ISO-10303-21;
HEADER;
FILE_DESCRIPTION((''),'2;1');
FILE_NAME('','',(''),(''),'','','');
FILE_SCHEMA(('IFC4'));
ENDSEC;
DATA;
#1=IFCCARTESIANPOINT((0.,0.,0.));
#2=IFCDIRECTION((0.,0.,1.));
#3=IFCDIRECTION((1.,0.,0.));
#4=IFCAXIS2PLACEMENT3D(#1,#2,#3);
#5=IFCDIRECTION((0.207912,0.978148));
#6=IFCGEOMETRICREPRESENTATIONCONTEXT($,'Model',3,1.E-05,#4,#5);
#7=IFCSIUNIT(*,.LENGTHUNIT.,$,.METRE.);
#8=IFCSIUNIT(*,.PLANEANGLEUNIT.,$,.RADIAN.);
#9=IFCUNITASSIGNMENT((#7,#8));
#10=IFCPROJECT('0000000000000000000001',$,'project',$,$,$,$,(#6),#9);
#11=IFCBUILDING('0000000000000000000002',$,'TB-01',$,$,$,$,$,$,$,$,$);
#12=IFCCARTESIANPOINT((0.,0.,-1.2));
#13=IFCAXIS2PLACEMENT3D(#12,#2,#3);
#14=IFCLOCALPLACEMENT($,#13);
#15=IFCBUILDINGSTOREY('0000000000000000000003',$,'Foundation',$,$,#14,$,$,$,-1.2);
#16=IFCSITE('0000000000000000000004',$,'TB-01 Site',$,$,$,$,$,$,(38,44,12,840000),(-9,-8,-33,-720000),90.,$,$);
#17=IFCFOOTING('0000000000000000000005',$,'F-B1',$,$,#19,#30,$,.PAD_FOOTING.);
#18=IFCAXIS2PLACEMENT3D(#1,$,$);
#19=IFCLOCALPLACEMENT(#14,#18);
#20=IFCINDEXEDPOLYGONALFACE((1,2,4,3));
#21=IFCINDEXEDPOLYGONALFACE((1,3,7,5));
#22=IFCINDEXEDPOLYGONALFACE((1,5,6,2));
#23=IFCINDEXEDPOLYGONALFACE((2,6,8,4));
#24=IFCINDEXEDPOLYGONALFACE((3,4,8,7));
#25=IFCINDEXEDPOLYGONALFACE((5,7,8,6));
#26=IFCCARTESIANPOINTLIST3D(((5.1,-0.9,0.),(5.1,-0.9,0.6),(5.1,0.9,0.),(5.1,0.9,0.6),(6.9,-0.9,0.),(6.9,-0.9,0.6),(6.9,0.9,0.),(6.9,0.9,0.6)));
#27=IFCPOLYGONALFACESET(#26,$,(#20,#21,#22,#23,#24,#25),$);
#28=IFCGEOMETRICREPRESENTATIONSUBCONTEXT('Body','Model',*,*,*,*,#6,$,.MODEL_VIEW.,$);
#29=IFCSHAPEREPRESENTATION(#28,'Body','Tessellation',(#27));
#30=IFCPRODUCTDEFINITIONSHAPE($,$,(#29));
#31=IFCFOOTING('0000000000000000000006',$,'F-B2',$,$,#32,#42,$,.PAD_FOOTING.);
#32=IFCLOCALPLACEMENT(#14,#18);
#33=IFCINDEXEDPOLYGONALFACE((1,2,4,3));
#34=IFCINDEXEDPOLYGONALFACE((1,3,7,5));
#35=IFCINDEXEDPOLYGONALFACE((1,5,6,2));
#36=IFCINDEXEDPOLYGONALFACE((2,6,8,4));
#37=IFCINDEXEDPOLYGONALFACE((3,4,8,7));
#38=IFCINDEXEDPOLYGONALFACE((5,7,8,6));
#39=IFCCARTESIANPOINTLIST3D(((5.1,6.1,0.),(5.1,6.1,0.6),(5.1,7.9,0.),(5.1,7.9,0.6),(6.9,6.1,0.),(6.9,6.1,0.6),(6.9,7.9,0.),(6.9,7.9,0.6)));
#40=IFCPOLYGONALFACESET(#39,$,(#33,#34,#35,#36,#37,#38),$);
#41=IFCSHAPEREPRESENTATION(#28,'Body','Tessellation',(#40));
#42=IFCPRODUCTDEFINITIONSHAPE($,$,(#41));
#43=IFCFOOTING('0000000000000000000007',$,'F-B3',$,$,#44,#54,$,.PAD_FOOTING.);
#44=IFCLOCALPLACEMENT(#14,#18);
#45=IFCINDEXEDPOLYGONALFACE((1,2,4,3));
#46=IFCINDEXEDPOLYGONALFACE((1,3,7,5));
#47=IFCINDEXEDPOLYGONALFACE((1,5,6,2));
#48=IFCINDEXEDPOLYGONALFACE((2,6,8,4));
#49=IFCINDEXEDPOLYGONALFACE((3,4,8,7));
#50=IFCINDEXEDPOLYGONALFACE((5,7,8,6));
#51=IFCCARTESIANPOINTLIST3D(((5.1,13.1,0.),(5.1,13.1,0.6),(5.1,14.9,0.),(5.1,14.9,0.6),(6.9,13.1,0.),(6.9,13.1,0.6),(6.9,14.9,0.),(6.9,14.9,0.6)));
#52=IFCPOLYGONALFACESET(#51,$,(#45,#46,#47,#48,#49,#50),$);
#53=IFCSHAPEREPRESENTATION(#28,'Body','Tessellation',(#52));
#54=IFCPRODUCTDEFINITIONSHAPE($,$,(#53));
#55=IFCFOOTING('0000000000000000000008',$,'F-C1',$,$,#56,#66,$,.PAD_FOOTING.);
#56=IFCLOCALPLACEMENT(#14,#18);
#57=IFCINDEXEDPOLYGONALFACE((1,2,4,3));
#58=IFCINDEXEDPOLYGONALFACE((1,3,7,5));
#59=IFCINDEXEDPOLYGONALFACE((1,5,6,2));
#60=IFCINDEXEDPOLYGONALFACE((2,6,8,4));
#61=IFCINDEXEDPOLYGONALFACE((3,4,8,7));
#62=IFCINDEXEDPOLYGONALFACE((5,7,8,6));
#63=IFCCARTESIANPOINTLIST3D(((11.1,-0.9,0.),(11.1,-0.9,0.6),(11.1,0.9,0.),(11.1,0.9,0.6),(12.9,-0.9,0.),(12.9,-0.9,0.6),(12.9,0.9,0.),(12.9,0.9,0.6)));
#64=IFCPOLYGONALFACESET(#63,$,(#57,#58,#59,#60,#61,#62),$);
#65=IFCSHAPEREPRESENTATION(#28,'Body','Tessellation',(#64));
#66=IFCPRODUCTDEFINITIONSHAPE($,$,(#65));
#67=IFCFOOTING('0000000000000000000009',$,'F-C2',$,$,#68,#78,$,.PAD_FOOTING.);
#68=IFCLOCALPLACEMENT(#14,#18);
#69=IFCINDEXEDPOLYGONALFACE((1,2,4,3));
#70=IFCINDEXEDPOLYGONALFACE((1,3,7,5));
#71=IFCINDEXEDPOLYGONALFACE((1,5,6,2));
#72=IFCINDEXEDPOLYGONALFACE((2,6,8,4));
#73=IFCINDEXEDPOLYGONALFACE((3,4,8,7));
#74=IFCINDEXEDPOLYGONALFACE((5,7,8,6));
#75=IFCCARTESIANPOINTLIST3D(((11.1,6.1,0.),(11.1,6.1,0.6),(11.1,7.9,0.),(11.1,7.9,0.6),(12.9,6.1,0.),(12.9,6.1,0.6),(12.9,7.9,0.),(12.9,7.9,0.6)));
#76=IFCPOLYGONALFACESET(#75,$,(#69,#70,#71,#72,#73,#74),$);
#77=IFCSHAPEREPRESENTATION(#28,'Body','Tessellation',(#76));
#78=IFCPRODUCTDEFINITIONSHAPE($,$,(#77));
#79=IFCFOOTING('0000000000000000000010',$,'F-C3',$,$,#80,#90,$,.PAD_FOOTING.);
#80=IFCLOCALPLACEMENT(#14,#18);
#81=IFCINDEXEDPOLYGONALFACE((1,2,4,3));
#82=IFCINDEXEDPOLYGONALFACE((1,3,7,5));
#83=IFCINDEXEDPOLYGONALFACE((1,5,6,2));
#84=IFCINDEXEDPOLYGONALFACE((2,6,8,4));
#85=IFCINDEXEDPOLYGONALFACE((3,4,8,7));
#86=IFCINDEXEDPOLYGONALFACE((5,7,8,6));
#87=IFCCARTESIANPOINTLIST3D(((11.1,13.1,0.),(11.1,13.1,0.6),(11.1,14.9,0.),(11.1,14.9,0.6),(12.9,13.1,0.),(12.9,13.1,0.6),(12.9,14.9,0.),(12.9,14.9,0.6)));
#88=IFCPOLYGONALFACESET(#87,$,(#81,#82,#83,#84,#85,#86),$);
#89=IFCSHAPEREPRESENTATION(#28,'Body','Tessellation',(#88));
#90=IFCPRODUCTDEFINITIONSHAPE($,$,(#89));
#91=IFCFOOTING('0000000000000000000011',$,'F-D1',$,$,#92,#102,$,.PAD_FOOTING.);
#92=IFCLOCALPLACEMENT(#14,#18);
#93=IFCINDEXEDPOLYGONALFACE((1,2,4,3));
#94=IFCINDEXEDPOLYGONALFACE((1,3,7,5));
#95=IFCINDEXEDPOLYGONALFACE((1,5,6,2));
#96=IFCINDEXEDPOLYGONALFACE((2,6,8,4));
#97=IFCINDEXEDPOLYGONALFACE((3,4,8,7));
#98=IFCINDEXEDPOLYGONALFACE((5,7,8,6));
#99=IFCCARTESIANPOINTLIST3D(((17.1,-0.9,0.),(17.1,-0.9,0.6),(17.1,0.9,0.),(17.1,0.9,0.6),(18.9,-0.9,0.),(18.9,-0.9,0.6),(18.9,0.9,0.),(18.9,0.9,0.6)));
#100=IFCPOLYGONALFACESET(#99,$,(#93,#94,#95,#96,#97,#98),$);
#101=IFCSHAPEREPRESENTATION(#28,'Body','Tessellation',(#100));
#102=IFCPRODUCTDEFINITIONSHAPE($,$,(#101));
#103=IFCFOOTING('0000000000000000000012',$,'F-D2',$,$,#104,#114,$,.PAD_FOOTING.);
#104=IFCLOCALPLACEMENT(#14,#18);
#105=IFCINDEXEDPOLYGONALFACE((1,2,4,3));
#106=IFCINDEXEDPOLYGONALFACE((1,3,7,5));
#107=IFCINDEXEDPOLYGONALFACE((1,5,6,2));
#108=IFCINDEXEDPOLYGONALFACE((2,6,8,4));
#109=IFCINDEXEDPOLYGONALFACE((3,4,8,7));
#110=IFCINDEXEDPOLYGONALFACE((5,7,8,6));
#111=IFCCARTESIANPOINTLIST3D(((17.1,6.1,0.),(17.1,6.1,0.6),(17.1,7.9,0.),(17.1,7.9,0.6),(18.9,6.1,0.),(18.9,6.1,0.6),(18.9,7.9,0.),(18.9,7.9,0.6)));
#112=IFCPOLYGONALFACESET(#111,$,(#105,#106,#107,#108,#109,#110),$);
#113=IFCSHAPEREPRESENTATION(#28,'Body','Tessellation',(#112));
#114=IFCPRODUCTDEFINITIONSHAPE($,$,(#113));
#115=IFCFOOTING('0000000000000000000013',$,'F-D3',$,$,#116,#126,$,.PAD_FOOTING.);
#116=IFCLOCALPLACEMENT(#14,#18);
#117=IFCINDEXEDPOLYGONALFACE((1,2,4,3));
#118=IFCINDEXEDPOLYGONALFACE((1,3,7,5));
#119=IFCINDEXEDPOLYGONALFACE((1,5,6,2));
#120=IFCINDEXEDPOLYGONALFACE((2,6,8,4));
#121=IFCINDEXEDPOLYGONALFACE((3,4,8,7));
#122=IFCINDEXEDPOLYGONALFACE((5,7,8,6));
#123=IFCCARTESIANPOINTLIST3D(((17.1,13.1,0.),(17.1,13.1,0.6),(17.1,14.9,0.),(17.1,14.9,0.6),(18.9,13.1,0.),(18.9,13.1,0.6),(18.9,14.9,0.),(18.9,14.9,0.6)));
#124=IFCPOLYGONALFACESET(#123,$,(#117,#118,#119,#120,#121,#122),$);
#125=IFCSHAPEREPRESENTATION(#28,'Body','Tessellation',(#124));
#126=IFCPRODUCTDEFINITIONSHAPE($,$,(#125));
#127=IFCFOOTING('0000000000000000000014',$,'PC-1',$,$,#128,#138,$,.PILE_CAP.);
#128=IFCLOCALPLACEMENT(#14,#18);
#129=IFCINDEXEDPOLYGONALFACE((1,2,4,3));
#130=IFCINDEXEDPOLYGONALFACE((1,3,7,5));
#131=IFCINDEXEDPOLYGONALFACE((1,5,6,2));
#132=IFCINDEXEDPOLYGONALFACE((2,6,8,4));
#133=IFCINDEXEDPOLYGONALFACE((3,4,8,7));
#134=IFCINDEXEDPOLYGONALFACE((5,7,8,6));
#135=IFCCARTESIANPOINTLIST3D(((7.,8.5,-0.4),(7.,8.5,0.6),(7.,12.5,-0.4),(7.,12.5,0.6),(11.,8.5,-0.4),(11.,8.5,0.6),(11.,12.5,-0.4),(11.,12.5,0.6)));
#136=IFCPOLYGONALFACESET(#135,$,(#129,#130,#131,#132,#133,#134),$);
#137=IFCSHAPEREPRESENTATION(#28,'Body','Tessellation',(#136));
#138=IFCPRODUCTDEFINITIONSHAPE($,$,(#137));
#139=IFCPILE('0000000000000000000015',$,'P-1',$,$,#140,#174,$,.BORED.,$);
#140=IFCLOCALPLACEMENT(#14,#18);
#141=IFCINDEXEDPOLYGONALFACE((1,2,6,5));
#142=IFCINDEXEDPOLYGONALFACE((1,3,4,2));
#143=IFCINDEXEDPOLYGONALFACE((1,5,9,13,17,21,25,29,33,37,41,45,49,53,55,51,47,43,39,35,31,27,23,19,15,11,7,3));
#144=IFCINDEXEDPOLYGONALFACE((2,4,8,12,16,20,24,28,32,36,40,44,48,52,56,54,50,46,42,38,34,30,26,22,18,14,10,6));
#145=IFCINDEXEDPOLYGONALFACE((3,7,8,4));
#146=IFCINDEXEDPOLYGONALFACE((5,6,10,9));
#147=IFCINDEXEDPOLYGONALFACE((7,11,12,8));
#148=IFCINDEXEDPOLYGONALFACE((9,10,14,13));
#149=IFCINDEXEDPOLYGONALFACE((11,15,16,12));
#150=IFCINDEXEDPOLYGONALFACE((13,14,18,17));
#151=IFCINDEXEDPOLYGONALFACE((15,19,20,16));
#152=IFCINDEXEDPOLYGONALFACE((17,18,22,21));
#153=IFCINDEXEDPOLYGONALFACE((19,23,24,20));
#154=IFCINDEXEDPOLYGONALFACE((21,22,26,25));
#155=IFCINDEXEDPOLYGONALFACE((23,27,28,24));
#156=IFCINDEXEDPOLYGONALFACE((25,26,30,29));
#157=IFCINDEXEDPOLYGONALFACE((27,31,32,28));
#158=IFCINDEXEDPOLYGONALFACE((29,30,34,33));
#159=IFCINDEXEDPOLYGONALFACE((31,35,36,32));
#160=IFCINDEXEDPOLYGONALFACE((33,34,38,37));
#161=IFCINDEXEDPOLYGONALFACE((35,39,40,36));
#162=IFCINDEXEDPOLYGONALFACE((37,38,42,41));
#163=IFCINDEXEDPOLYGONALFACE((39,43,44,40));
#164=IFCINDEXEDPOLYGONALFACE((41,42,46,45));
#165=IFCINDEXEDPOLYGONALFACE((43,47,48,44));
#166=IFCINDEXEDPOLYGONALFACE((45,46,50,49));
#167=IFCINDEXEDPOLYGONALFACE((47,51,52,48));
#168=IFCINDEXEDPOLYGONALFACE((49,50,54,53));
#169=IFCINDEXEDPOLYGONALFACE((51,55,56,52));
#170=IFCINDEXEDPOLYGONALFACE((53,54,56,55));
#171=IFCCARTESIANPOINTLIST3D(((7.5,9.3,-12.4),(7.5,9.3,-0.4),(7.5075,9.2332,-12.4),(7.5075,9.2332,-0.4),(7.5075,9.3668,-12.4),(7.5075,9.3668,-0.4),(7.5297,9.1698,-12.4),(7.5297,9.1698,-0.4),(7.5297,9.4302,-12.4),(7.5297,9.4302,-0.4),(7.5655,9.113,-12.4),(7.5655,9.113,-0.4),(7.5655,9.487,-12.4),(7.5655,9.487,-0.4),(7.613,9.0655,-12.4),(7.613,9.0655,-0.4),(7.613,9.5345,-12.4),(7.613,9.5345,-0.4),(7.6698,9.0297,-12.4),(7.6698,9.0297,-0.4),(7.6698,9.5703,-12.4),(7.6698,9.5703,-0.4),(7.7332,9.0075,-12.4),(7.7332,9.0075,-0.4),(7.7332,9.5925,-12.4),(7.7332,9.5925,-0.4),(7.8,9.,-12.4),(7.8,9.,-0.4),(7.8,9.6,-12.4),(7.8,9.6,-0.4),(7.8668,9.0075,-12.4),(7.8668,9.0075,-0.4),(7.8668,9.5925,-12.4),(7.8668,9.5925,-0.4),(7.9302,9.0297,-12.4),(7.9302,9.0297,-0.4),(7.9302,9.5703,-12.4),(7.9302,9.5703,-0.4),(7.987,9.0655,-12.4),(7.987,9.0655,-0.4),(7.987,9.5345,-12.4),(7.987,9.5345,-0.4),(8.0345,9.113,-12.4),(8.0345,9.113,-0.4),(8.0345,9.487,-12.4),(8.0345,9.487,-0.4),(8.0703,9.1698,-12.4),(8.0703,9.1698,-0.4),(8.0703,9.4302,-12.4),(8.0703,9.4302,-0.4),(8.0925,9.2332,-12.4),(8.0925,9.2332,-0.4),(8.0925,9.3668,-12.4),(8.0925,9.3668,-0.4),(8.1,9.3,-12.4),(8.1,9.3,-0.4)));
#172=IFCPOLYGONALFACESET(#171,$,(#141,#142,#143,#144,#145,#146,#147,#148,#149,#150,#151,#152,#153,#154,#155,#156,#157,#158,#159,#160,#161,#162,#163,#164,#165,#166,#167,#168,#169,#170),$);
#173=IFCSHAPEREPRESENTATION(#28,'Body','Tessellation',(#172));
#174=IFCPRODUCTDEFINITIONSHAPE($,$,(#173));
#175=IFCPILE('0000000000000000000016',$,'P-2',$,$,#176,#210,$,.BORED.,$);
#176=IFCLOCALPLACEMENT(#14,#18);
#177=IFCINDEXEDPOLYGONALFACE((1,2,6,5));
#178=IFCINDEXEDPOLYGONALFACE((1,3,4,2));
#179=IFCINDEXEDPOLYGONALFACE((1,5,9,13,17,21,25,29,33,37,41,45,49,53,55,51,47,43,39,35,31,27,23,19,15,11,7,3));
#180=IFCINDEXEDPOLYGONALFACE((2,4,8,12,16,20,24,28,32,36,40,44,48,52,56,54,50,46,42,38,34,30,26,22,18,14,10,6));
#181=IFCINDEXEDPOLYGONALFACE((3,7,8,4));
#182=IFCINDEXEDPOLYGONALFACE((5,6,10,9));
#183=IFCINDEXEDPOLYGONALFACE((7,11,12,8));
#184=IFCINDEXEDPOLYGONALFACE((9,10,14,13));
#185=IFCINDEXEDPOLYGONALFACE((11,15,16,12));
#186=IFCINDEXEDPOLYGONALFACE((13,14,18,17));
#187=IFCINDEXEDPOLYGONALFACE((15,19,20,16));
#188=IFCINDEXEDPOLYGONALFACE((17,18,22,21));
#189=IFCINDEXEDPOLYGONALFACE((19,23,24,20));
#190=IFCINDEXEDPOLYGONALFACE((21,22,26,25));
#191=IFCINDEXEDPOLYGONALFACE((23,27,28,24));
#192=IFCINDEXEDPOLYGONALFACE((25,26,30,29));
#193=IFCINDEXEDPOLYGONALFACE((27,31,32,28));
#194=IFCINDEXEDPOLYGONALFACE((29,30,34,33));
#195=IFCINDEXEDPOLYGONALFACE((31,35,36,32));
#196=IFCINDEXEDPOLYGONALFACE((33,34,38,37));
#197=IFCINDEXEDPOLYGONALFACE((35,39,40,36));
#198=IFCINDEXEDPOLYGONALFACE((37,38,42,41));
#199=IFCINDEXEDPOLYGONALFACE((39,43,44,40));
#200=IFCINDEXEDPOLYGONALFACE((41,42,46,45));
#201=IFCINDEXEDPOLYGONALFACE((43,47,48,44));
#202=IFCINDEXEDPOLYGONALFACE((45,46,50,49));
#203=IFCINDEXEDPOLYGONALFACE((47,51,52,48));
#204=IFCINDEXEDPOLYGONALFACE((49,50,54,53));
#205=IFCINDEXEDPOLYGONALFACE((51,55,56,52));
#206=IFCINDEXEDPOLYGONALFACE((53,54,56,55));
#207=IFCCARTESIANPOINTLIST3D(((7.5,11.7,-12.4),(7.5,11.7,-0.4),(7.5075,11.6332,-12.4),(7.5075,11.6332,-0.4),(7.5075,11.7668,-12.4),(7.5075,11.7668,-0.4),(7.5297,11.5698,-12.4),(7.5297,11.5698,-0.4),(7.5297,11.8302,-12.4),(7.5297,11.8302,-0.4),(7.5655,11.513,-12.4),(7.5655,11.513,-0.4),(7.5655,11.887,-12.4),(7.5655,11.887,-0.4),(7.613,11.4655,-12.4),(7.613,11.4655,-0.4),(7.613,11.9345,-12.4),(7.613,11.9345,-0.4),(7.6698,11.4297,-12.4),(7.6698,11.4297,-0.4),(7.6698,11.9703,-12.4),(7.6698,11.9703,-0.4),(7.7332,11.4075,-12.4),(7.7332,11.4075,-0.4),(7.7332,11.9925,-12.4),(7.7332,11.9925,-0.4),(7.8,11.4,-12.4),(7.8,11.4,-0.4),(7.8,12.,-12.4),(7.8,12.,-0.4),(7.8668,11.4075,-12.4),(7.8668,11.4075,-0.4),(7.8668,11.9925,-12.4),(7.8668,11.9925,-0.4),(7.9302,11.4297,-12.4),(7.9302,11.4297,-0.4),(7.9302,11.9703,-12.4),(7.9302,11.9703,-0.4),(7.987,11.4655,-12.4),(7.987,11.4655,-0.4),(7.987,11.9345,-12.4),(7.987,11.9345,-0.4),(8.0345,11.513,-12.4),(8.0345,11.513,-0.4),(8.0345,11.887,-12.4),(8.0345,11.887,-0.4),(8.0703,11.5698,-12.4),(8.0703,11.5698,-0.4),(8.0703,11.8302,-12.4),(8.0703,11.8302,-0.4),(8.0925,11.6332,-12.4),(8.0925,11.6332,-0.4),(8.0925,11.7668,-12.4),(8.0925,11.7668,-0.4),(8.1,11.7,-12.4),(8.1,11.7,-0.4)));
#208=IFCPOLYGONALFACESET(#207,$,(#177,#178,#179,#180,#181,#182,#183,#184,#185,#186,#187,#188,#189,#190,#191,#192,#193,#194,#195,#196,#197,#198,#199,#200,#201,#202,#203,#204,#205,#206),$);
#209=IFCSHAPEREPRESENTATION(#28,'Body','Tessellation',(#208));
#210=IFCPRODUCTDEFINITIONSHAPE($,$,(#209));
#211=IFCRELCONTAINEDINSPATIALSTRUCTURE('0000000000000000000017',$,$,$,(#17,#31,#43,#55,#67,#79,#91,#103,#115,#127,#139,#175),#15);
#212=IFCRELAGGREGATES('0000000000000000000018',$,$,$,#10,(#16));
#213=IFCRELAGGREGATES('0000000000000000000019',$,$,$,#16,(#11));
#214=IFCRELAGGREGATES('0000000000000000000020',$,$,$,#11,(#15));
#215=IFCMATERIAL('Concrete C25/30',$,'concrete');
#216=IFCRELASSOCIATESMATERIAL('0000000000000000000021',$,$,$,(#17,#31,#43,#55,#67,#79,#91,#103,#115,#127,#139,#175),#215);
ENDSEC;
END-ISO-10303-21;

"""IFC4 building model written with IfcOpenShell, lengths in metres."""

from ifc_helpers import new_model, si_unit, direction, frame, origin_with_axes, place, context, subcontext, project, spatial, rectangle, circle, extrude, material, element, save


model = new_model("IFC4")

# Units and contexts
model_context = context("Model", 3, precision=1e-05, world=origin_with_axes(), true_north=direction((0.207912, 0.978148)))
body_context = subcontext(model_context, "Body", "Model", "MODEL_VIEW")
ifc_project = project(units=[si_unit("LENGTHUNIT", "METRE"), si_unit("PLANEANGLEUNIT", "RADIAN")], contexts=[model_context])

# Site, building, storey
site = spatial("IfcSite", under=ifc_project, Name="TB-01 Site", RefLatitude=(38, 44, 12, 840000), RefLongitude=(-9, -8, -33, -720000), RefElevation=90.0)
building = spatial("IfcBuilding", under=site, Name="TB-01")
storey_placement = place(None, frame((0.0, 0.0, -1.2), z_axis=(0.0, 0.0, 1.0), x_axis=(1.0, 0.0, 0.0)))
storey = spatial("IfcBuildingStorey", under=building, at=storey_placement, Name="Foundation", Elevation=-1.2)

# Footings
ifc_material_1 = material(Name="Concrete C25/30", Category="concrete")
footing_1_placement = place(storey_placement, frame((6.0, 0.0, 0.0), z_axis=(0.0, 0.0, 1.0), x_axis=(1.0, 0.0, 0.0)))
element("IfcFooting", 1, at=footing_1_placement, inside=storey, material=ifc_material_1, Name="F-B1", PredefinedType="PAD_FOOTING", context=body_context, shape_type="SweptSolid", body=[
    extrude(rectangle(XDim=1.8, YDim=1.8), origin_with_axes(), (0.0, 0.0, 1.0), 0.6),
])
for number, where, z_axis, x_axis, name in (
    (2, (6.0, 7.0, 0.0), (0.0, 0.0, 1.0), (1.0, 0.0, 0.0), "F-B2"),
    (3, (6.0, 14.0, 0.0), (0.0, 0.0, 1.0), (1.0, 0.0, 0.0), "F-B3"),
):
    element("IfcFooting", number, at=place(storey_placement, frame(where, z_axis=z_axis, x_axis=x_axis)), inside=storey, material=ifc_material_1, Name=name, PredefinedType="PAD_FOOTING", context=body_context, shape_type="SweptSolid", body=[
        extrude(rectangle(XDim=1.8, YDim=1.8), origin_with_axes(), (0.0, 0.0, 1.0), 0.6),
    ])
footing_2_placement = place(storey_placement, frame((12.0, 0.0, 0.0), z_axis=(0.0, 0.0, 1.0), x_axis=(1.0, 0.0, 0.0)))
element("IfcFooting", 4, at=footing_2_placement, inside=storey, material=ifc_material_1, Name="F-C1", PredefinedType="PAD_FOOTING", context=body_context, shape_type="SweptSolid", body=[
    extrude(rectangle(XDim=1.8, YDim=1.8), origin_with_axes(), (0.0, 0.0, 1.0), 0.6),
])
for number, where, z_axis, x_axis, name in (
    (5, (12.0, 7.0, 0.0), (0.0, 0.0, 1.0), (1.0, 0.0, 0.0), "F-C2"),
    (6, (12.0, 14.0, 0.0), (0.0, 0.0, 1.0), (1.0, 0.0, 0.0), "F-C3"),
):
    element("IfcFooting", number, at=place(storey_placement, frame(where, z_axis=z_axis, x_axis=x_axis)), inside=storey, material=ifc_material_1, Name=name, PredefinedType="PAD_FOOTING", context=body_context, shape_type="SweptSolid", body=[
        extrude(rectangle(XDim=1.8, YDim=1.8), origin_with_axes(), (0.0, 0.0, 1.0), 0.6),
    ])
footing_3_placement = place(storey_placement, frame((18.0, 0.0, 0.0), z_axis=(0.0, 0.0, 1.0), x_axis=(1.0, 0.0, 0.0)))
element("IfcFooting", 7, at=footing_3_placement, inside=storey, material=ifc_material_1, Name="F-D1", PredefinedType="PAD_FOOTING", context=body_context, shape_type="SweptSolid", body=[
    extrude(rectangle(XDim=1.8, YDim=1.8), origin_with_axes(), (0.0, 0.0, 1.0), 0.6),
])
for number, where, z_axis, x_axis, name in (
    (8, (18.0, 7.0, 0.0), (0.0, 0.0, 1.0), (1.0, 0.0, 0.0), "F-D2"),
    (9, (18.0, 14.0, 0.0), (0.0, 0.0, 1.0), (1.0, 0.0, 0.0), "F-D3"),
):
    element("IfcFooting", number, at=place(storey_placement, frame(where, z_axis=z_axis, x_axis=x_axis)), inside=storey, material=ifc_material_1, Name=name, PredefinedType="PAD_FOOTING", context=body_context, shape_type="SweptSolid", body=[
        extrude(rectangle(XDim=1.8, YDim=1.8), origin_with_axes(), (0.0, 0.0, 1.0), 0.6),
    ])
footing_4_placement = place(storey_placement, frame((9.0, 10.5, -0.4), z_axis=(0.0, 0.0, 1.0), x_axis=(1.0, 0.0, 0.0)))
element("IfcFooting", 10, at=footing_4_placement, inside=storey, material=ifc_material_1, Name="PC-1", PredefinedType="PILE_CAP", context=body_context, shape_type="SweptSolid", body=[
    extrude(rectangle(XDim=4.0, YDim=4.0), origin_with_axes(), (0.0, 0.0, 1.0), 1.0),
])

# Piles
for number, where, z_axis, x_axis, name in (
    (11, (7.8, 9.3, -12.4), (0.0, 0.0, 1.0), (1.0, 0.0, 0.0), "P-1"),
    (12, (7.8, 11.7, -12.4), (0.0, 0.0, 1.0), (1.0, 0.0, 0.0), "P-2"),
):
    element("IfcPile", number, at=place(storey_placement, frame(where, z_axis=z_axis, x_axis=x_axis)), inside=storey, material=ifc_material_1, Name=name, PredefinedType="BORED", context=body_context, shape_type="SweptSolid", body=[
        extrude(circle(Radius=0.3), origin_with_axes(), (0.0, 0.0, 1.0), 12.0),
    ])

save(model, "model.ifc")
